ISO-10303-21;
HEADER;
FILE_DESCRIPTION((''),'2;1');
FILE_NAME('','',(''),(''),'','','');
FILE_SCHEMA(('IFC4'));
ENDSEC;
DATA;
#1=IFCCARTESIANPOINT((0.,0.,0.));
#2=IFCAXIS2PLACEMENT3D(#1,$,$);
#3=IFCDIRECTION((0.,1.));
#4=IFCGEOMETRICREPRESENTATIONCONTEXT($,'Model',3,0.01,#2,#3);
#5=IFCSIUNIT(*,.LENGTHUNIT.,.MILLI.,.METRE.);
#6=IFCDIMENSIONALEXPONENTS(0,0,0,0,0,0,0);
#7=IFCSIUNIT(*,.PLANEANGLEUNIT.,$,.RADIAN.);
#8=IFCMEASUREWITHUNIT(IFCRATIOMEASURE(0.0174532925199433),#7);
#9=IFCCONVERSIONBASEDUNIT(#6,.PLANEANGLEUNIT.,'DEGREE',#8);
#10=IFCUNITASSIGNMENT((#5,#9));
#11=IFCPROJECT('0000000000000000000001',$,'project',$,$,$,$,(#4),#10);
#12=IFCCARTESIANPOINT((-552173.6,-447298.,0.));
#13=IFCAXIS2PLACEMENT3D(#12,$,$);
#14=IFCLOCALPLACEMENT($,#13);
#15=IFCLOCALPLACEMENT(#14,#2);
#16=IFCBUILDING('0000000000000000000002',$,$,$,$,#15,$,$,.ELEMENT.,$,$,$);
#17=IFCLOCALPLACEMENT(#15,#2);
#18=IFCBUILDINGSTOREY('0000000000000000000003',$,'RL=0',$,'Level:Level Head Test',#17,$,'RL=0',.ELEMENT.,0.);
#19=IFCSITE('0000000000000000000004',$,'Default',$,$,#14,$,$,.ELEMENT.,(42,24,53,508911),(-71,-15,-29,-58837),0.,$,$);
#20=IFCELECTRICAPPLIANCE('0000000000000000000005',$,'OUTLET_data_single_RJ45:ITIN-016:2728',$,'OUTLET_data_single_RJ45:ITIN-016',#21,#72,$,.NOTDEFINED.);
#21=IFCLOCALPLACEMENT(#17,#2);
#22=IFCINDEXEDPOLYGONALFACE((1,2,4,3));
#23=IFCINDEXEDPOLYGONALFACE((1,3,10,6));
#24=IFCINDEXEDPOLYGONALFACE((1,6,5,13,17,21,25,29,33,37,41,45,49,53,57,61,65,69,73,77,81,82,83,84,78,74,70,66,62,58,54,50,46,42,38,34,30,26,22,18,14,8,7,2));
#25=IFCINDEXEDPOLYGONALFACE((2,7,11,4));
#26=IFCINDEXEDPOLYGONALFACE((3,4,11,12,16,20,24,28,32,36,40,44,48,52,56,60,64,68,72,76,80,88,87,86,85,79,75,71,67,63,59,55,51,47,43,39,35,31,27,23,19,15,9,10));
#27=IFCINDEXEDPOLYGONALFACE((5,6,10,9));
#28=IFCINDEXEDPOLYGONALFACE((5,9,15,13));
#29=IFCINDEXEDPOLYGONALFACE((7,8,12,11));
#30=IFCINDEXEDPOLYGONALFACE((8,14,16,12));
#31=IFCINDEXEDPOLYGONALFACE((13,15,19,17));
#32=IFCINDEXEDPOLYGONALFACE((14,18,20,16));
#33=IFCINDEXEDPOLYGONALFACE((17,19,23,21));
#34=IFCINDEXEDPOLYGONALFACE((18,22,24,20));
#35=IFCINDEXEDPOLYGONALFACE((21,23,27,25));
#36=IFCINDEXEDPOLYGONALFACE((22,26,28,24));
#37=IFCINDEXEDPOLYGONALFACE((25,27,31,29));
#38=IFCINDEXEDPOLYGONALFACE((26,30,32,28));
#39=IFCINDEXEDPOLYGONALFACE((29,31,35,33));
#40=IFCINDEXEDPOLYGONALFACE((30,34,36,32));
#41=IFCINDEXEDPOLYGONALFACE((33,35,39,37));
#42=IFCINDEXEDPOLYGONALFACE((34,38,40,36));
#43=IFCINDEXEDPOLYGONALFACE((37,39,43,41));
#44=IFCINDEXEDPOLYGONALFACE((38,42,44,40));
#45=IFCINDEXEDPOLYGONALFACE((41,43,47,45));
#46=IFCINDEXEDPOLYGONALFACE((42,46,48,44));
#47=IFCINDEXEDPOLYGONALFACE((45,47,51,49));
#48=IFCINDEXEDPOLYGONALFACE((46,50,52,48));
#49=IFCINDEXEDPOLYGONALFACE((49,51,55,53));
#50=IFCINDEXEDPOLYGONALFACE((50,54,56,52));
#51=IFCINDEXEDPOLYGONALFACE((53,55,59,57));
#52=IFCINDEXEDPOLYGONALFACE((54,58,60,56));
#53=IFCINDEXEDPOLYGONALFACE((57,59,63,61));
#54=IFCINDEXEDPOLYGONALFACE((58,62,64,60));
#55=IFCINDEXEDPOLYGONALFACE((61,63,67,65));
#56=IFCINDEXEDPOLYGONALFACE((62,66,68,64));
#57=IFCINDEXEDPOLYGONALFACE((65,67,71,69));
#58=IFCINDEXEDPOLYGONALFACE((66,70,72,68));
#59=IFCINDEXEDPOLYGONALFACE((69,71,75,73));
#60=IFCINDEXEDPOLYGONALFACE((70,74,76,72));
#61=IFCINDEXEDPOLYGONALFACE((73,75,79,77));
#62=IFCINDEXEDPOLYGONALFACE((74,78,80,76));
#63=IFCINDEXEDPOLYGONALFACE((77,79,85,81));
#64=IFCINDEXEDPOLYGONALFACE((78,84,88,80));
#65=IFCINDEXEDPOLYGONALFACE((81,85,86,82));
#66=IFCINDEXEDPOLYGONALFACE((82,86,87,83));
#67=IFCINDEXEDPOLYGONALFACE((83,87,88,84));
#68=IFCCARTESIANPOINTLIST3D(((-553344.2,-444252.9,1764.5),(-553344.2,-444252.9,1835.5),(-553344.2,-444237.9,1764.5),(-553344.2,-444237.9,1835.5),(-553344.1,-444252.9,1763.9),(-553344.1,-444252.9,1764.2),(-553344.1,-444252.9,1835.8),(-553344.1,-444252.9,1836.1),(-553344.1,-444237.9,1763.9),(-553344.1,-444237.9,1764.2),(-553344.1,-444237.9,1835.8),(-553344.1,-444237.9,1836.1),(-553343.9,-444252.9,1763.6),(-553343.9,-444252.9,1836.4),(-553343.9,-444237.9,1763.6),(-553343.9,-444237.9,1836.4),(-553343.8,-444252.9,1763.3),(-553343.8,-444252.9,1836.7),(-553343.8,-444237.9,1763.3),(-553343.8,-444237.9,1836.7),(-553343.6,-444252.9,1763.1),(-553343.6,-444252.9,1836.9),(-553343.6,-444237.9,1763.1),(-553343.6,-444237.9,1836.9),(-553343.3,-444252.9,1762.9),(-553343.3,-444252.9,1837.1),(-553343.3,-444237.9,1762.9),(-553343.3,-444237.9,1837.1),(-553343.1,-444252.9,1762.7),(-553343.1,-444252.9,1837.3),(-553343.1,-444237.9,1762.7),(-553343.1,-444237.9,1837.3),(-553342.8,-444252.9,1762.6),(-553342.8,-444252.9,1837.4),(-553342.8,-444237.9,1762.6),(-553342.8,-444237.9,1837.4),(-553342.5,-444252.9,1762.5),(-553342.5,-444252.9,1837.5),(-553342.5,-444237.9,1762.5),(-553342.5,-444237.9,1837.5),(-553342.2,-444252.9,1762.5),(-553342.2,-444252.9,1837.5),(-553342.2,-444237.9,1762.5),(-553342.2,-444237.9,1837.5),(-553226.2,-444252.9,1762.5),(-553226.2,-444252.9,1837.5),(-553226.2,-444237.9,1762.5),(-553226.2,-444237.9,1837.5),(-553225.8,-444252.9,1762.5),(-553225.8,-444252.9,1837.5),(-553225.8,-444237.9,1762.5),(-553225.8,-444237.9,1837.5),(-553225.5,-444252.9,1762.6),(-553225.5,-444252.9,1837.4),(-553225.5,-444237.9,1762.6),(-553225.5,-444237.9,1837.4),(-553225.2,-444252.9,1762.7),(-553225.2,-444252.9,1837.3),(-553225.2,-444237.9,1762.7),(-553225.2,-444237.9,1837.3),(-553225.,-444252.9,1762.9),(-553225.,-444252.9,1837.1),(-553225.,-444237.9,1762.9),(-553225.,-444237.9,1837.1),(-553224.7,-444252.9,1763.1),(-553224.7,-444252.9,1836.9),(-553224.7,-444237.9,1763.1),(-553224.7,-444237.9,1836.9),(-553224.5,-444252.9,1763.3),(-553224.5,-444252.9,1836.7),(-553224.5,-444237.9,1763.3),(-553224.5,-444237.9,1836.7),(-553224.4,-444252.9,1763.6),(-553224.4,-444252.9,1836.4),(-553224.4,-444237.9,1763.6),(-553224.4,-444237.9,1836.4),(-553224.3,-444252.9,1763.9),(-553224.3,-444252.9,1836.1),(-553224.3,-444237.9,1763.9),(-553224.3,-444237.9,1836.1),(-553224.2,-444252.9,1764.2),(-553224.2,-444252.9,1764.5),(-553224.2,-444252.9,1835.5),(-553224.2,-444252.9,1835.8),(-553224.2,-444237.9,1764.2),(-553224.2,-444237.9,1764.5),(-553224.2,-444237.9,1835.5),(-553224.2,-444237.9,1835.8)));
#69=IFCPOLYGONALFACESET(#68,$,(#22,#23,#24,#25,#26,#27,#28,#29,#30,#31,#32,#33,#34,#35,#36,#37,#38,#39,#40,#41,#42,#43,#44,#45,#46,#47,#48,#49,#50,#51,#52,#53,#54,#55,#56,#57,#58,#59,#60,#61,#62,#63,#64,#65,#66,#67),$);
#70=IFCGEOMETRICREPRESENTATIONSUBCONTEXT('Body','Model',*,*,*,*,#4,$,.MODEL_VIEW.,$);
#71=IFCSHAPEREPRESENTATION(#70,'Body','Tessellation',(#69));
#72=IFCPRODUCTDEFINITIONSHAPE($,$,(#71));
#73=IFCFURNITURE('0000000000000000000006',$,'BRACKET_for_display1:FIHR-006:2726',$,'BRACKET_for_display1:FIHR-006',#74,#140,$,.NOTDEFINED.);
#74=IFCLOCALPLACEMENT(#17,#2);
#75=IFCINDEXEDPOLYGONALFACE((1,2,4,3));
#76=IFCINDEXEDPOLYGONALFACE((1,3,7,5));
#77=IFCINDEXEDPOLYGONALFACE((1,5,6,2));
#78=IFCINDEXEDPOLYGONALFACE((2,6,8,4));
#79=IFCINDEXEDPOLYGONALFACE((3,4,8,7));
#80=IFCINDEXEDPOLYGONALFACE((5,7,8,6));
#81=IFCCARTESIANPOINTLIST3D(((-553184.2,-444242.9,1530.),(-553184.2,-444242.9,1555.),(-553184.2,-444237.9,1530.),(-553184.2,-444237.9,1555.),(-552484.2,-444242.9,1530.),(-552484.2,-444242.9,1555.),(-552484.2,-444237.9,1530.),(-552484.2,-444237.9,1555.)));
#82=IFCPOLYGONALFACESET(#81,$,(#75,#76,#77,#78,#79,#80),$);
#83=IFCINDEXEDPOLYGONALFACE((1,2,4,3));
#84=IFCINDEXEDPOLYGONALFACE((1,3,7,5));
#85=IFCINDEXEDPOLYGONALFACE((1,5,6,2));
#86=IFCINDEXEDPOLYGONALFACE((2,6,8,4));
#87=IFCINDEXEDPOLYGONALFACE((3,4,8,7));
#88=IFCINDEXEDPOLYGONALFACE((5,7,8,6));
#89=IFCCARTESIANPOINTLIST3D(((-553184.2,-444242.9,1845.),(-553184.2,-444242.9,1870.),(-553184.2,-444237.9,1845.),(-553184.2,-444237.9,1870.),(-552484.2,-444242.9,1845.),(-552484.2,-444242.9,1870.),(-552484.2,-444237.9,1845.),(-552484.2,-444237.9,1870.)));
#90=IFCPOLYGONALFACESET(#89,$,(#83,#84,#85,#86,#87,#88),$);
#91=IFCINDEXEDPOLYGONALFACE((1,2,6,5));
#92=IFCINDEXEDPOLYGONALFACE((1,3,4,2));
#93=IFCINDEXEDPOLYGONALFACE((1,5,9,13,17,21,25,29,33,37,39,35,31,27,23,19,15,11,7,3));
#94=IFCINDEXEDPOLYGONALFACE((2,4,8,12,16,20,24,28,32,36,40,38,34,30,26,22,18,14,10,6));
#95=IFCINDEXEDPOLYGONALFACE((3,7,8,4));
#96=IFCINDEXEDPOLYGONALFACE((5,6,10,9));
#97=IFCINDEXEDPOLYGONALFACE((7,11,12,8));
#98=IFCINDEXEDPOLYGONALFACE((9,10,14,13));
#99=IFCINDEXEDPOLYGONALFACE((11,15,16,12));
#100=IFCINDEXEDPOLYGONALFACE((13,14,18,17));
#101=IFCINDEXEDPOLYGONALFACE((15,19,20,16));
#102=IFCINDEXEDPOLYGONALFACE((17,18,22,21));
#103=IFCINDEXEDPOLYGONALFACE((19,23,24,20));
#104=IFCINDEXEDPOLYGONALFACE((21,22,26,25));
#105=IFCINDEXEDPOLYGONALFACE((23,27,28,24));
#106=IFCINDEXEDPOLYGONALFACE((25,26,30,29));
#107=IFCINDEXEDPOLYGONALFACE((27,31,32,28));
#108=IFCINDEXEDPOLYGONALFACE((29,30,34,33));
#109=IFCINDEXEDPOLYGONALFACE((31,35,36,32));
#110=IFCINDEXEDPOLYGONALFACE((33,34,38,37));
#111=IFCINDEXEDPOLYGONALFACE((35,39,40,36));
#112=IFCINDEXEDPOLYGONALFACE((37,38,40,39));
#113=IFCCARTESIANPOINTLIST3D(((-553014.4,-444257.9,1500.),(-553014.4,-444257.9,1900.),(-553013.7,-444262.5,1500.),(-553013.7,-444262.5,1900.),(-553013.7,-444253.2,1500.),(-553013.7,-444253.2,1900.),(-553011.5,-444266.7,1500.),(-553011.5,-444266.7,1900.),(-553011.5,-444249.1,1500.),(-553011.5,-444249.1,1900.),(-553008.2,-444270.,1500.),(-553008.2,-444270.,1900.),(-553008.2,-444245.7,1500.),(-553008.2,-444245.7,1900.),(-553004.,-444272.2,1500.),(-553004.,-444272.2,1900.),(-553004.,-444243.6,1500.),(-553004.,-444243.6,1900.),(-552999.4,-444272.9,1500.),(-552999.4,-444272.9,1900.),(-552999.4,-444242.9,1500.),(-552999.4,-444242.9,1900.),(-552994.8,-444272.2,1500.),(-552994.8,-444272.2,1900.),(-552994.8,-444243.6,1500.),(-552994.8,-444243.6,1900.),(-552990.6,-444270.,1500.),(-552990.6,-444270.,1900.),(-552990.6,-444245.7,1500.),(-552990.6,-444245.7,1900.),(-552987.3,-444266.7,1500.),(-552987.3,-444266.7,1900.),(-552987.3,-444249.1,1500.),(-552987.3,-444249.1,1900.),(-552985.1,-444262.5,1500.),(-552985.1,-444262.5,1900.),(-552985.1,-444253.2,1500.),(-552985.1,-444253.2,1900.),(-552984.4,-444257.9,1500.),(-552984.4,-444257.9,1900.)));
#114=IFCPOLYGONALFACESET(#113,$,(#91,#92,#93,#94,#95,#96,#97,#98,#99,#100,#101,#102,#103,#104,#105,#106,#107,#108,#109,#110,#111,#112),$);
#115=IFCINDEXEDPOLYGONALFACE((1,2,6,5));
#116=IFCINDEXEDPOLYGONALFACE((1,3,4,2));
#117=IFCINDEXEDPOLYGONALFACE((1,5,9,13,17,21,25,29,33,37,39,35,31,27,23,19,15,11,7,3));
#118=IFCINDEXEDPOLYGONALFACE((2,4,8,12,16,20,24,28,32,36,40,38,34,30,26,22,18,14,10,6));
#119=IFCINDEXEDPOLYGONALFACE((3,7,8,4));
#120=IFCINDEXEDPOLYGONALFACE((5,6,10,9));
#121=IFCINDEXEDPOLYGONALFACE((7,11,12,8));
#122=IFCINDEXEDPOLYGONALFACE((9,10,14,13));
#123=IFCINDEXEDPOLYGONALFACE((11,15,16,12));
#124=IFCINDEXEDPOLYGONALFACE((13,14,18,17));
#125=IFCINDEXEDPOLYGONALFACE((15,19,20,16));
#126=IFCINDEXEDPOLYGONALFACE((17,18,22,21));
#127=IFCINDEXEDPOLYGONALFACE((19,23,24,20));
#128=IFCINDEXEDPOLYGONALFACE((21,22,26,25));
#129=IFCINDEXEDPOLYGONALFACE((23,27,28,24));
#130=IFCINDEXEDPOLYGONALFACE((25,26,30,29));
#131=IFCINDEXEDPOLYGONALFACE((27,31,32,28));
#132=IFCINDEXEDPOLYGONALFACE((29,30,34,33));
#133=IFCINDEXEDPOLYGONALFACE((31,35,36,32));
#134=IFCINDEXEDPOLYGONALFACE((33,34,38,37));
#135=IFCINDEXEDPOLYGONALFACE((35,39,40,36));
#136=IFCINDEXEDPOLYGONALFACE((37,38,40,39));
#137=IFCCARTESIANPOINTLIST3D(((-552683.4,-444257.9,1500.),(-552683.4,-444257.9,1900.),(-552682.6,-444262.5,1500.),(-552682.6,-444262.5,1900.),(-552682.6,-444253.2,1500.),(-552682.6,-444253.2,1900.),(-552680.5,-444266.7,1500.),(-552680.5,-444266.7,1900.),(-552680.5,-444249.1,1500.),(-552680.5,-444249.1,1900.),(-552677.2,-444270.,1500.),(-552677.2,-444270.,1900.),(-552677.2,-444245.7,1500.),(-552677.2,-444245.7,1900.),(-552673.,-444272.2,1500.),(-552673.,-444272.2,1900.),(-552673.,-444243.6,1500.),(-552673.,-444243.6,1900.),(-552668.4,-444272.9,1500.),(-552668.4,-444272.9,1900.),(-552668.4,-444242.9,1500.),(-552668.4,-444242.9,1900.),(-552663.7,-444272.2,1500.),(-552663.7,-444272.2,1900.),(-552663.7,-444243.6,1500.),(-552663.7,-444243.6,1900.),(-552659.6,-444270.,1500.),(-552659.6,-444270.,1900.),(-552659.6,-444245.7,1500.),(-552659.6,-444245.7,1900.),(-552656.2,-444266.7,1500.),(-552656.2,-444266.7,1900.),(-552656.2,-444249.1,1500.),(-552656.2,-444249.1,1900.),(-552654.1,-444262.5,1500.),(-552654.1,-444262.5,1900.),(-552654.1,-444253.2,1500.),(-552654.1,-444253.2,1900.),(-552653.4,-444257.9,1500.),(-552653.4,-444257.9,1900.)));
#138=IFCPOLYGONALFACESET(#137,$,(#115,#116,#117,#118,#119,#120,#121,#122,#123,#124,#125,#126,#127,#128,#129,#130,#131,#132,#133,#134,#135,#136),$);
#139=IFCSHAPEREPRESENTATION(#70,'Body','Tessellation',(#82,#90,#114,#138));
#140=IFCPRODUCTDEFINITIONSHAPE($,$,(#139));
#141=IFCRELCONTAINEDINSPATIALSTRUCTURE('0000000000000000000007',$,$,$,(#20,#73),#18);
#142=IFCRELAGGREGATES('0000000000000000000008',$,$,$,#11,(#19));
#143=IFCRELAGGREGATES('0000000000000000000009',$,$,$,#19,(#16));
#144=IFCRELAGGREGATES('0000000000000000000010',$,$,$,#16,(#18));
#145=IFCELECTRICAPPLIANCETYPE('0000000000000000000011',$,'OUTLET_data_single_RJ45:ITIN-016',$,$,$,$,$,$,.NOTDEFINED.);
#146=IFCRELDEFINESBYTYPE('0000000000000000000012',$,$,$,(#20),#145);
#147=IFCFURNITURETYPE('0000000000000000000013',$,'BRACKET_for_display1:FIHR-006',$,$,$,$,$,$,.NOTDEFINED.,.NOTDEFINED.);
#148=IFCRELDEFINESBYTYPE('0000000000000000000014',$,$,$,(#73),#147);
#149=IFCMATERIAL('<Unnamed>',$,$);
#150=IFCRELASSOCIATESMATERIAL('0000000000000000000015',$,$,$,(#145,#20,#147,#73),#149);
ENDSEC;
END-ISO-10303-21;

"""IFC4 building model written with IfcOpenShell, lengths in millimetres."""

from ifc_helpers import new_model, entity, si_unit, converted_unit, direction, frame, origin, place, context, subcontext, project, spatial, indexed_curve, outline, extrude, source, transform, mapped, material, type_object, type_shapes, element, save


model = new_model("IFC4")

# Units and contexts
model_context = context("Model", 3, precision=0.01, world=origin(), true_north=direction((0.0, 1.0)))
body_context = subcontext(model_context, "Body", "Model", "MODEL_VIEW")
ifc_project = project(units=[si_unit("LENGTHUNIT", "METRE", prefix="MILLI"), converted_unit("PLANEANGLEUNIT", "DEGREE", entity("IfcRatioMeasure", 0.0174532925199433), si_unit("PLANEANGLEUNIT", "RADIAN"), dimensions=[0, 0, 0, 0, 0, 0, 0])], contexts=[model_context])

# Site, building, storey
site_placement = place(None, frame((-552173.6, -447298.0, 0.0)))
site = spatial("IfcSite", under=ifc_project, at=site_placement, Name="Default", CompositionType="ELEMENT", RefLatitude=(42, 24, 53, 508911), RefLongitude=(-71, -15, -29, -58837), RefElevation=0.0)
building_placement = place(site_placement, origin())
building = spatial("IfcBuilding", under=site, at=building_placement, CompositionType="ELEMENT")
storey_placement = place(building_placement, origin())
storey = spatial("IfcBuildingStorey", under=building, at=storey_placement, Name="RL=0", ObjectType="Level:Level Head Test", LongName="RL=0", CompositionType="ELEMENT", Elevation=0.0)

# Electric appliance
ifc_material_1 = material(Name="<Unnamed>")
electric_appliance_type_1 = type_object("IfcElectricApplianceType", Name="OUTLET_data_single_RJ45:ITIN-016", PredefinedType="NOTDEFINED", material=ifc_material_1)
shared_shape_1 = source(origin(), body_context, "Body", "SweptSolid", [
    extrude(outline(indexed_curve([(-35.5, -60.0), (35.5, -60.0), (35.8, -60.0), (36.1, -59.9), (36.4, -59.8), (36.7, -59.6), (36.9, -59.4), (37.1, -59.2), (37.3, -58.9), (37.4, -58.6), (37.5, -58.3), (37.5, -58.0), (37.5, 58.0), (37.5, 58.3), (37.4, 58.6), (37.3, 58.9), (37.1, 59.2), (36.9, 59.4), (36.7, 59.6), (36.4, 59.8), (36.1, 59.9), (35.8, 60.0), (35.5, 60.0), (-35.5, 60.0), (-35.8, 60.0), (-36.1, 59.9), (-36.4, 59.8), (-36.7, 59.6), (-36.9, 59.4), (-37.1, 59.2), (-37.3, 58.9), (-37.4, 58.6), (-37.5, 58.3), (-37.5, 58.0), (-37.5, -58.0), (-37.5, -58.3), (-37.4, -58.6), (-37.3, -58.9), (-37.1, -59.2), (-36.9, -59.4), (-36.7, -59.6), (-36.4, -59.8), (-36.1, -59.9), (-35.8, -60.0), (-35.5, -60.0)], self_intersect=False)), frame((0.0, 0.0, 0.0), z_axis=(0.0, 1.0, 0.0), x_axis=(0.0, 0.0, 1.0)), (0.0, 0.0, 1.0), 15.0),
])
type_shapes(electric_appliance_type_1, [shared_shape_1])
electric_appliance_placement = place(storey_placement, frame((-553284.2, -444237.9, 1800.0), z_axis=(0.0, 0.0, 1.0), x_axis=(-1.0, 0.0, 0.0)))
element("IfcElectricAppliance", 1, at=electric_appliance_placement, inside=storey, type_object=electric_appliance_type_1, material=ifc_material_1, Name="OUTLET_data_single_RJ45:ITIN-016:2728", ObjectType="OUTLET_data_single_RJ45:ITIN-016", PredefinedType="NOTDEFINED", context=body_context, shape_type="MappedRepresentation", body=[
    mapped(shared_shape_1, transform((0.0, 0.0, 0.0), scale=1.0)),
])

# Furniture
furniture_type_1 = type_object("IfcFurnitureType", Name="BRACKET_for_display1:FIHR-006", AssemblyPlace="NOTDEFINED", PredefinedType="NOTDEFINED", material=ifc_material_1)
shared_shape_2 = source(origin(), body_context, "Body", "SweptSolid", [
    extrude(outline(indexed_curve([(-350.0, -2.5), (350.0, -2.5), (350.0, 2.5), (-350.0, 2.5), (-350.0, -2.5)], self_intersect=False)), frame((350.0, 2.5, 30.0), z_axis=(0.0, 0.0, 1.0), x_axis=(-1.0, 0.0, 0.0)), (0.0, 0.0, 1.0), 25.0),
    extrude(outline(indexed_curve([(-350.0, -2.5), (350.0, -2.5), (350.0, 2.5), (-350.0, 2.5), (-350.0, -2.5)], self_intersect=False)), frame((350.0, 2.5, 345.0), z_axis=(0.0, 0.0, 1.0), x_axis=(-1.0, 0.0, 0.0)), (0.0, 0.0, 1.0), 25.0),
    extrude(outline(indexed_curve([(15.0, 0.0), (14.3, 4.6), (12.1, 8.8), (8.8, 12.1), (4.6, 14.3), (0.0, 15.0), (-4.6, 14.3), (-8.8, 12.1), (-12.1, 8.8), (-14.3, 4.6), (-15.0, 0.0), (-14.3, -4.6), (-12.1, -8.8), (-8.8, -12.1), (-4.6, -14.3), (0.0, -15.0), (4.6, -14.3), (8.8, -12.1), (12.1, -8.8), (14.3, -4.6), (15.0, 0.0)], self_intersect=False)), frame((515.2, 20.0, 0.0), z_axis=(0.0, 0.0, 1.0), x_axis=(0.0, 1.0, 0.0)), (0.0, 0.0, 1.0), 400.0),
    extrude(outline(indexed_curve([(15.0, 0.0), (14.3, 4.6), (12.1, 8.8), (8.8, 12.1), (4.6, 14.3), (0.0, 15.0), (-4.6, 14.3), (-8.8, 12.1), (-12.1, 8.8), (-14.3, 4.6), (-15.0, 0.0), (-14.3, -4.6), (-12.1, -8.8), (-8.8, -12.1), (-4.6, -14.3), (0.0, -15.0), (4.6, -14.3), (8.8, -12.1), (12.1, -8.8), (14.3, -4.6), (15.0, 0.0)], self_intersect=False)), frame((184.2, 20.0, 0.0), z_axis=(0.0, 0.0, 1.0), x_axis=(0.0, 1.0, 0.0)), (0.0, 0.0, 1.0), 400.0),
])
type_shapes(furniture_type_1, [shared_shape_2])
furniture_1_placement = place(storey_placement, frame((-552484.2, -444237.9, 1500.0), z_axis=(0.0, 0.0, 1.0), x_axis=(-1.0, 0.0, 0.0)))
element("IfcFurniture", 2, at=furniture_1_placement, inside=storey, type_object=furniture_type_1, material=ifc_material_1, Name="BRACKET_for_display1:FIHR-006:2726", ObjectType="BRACKET_for_display1:FIHR-006", PredefinedType="NOTDEFINED", context=body_context, shape_type="MappedRepresentation", body=[
    mapped(shared_shape_2, transform((0.0, 0.0, 0.0), scale=1.0)),
])

save(model, "model.ifc")
